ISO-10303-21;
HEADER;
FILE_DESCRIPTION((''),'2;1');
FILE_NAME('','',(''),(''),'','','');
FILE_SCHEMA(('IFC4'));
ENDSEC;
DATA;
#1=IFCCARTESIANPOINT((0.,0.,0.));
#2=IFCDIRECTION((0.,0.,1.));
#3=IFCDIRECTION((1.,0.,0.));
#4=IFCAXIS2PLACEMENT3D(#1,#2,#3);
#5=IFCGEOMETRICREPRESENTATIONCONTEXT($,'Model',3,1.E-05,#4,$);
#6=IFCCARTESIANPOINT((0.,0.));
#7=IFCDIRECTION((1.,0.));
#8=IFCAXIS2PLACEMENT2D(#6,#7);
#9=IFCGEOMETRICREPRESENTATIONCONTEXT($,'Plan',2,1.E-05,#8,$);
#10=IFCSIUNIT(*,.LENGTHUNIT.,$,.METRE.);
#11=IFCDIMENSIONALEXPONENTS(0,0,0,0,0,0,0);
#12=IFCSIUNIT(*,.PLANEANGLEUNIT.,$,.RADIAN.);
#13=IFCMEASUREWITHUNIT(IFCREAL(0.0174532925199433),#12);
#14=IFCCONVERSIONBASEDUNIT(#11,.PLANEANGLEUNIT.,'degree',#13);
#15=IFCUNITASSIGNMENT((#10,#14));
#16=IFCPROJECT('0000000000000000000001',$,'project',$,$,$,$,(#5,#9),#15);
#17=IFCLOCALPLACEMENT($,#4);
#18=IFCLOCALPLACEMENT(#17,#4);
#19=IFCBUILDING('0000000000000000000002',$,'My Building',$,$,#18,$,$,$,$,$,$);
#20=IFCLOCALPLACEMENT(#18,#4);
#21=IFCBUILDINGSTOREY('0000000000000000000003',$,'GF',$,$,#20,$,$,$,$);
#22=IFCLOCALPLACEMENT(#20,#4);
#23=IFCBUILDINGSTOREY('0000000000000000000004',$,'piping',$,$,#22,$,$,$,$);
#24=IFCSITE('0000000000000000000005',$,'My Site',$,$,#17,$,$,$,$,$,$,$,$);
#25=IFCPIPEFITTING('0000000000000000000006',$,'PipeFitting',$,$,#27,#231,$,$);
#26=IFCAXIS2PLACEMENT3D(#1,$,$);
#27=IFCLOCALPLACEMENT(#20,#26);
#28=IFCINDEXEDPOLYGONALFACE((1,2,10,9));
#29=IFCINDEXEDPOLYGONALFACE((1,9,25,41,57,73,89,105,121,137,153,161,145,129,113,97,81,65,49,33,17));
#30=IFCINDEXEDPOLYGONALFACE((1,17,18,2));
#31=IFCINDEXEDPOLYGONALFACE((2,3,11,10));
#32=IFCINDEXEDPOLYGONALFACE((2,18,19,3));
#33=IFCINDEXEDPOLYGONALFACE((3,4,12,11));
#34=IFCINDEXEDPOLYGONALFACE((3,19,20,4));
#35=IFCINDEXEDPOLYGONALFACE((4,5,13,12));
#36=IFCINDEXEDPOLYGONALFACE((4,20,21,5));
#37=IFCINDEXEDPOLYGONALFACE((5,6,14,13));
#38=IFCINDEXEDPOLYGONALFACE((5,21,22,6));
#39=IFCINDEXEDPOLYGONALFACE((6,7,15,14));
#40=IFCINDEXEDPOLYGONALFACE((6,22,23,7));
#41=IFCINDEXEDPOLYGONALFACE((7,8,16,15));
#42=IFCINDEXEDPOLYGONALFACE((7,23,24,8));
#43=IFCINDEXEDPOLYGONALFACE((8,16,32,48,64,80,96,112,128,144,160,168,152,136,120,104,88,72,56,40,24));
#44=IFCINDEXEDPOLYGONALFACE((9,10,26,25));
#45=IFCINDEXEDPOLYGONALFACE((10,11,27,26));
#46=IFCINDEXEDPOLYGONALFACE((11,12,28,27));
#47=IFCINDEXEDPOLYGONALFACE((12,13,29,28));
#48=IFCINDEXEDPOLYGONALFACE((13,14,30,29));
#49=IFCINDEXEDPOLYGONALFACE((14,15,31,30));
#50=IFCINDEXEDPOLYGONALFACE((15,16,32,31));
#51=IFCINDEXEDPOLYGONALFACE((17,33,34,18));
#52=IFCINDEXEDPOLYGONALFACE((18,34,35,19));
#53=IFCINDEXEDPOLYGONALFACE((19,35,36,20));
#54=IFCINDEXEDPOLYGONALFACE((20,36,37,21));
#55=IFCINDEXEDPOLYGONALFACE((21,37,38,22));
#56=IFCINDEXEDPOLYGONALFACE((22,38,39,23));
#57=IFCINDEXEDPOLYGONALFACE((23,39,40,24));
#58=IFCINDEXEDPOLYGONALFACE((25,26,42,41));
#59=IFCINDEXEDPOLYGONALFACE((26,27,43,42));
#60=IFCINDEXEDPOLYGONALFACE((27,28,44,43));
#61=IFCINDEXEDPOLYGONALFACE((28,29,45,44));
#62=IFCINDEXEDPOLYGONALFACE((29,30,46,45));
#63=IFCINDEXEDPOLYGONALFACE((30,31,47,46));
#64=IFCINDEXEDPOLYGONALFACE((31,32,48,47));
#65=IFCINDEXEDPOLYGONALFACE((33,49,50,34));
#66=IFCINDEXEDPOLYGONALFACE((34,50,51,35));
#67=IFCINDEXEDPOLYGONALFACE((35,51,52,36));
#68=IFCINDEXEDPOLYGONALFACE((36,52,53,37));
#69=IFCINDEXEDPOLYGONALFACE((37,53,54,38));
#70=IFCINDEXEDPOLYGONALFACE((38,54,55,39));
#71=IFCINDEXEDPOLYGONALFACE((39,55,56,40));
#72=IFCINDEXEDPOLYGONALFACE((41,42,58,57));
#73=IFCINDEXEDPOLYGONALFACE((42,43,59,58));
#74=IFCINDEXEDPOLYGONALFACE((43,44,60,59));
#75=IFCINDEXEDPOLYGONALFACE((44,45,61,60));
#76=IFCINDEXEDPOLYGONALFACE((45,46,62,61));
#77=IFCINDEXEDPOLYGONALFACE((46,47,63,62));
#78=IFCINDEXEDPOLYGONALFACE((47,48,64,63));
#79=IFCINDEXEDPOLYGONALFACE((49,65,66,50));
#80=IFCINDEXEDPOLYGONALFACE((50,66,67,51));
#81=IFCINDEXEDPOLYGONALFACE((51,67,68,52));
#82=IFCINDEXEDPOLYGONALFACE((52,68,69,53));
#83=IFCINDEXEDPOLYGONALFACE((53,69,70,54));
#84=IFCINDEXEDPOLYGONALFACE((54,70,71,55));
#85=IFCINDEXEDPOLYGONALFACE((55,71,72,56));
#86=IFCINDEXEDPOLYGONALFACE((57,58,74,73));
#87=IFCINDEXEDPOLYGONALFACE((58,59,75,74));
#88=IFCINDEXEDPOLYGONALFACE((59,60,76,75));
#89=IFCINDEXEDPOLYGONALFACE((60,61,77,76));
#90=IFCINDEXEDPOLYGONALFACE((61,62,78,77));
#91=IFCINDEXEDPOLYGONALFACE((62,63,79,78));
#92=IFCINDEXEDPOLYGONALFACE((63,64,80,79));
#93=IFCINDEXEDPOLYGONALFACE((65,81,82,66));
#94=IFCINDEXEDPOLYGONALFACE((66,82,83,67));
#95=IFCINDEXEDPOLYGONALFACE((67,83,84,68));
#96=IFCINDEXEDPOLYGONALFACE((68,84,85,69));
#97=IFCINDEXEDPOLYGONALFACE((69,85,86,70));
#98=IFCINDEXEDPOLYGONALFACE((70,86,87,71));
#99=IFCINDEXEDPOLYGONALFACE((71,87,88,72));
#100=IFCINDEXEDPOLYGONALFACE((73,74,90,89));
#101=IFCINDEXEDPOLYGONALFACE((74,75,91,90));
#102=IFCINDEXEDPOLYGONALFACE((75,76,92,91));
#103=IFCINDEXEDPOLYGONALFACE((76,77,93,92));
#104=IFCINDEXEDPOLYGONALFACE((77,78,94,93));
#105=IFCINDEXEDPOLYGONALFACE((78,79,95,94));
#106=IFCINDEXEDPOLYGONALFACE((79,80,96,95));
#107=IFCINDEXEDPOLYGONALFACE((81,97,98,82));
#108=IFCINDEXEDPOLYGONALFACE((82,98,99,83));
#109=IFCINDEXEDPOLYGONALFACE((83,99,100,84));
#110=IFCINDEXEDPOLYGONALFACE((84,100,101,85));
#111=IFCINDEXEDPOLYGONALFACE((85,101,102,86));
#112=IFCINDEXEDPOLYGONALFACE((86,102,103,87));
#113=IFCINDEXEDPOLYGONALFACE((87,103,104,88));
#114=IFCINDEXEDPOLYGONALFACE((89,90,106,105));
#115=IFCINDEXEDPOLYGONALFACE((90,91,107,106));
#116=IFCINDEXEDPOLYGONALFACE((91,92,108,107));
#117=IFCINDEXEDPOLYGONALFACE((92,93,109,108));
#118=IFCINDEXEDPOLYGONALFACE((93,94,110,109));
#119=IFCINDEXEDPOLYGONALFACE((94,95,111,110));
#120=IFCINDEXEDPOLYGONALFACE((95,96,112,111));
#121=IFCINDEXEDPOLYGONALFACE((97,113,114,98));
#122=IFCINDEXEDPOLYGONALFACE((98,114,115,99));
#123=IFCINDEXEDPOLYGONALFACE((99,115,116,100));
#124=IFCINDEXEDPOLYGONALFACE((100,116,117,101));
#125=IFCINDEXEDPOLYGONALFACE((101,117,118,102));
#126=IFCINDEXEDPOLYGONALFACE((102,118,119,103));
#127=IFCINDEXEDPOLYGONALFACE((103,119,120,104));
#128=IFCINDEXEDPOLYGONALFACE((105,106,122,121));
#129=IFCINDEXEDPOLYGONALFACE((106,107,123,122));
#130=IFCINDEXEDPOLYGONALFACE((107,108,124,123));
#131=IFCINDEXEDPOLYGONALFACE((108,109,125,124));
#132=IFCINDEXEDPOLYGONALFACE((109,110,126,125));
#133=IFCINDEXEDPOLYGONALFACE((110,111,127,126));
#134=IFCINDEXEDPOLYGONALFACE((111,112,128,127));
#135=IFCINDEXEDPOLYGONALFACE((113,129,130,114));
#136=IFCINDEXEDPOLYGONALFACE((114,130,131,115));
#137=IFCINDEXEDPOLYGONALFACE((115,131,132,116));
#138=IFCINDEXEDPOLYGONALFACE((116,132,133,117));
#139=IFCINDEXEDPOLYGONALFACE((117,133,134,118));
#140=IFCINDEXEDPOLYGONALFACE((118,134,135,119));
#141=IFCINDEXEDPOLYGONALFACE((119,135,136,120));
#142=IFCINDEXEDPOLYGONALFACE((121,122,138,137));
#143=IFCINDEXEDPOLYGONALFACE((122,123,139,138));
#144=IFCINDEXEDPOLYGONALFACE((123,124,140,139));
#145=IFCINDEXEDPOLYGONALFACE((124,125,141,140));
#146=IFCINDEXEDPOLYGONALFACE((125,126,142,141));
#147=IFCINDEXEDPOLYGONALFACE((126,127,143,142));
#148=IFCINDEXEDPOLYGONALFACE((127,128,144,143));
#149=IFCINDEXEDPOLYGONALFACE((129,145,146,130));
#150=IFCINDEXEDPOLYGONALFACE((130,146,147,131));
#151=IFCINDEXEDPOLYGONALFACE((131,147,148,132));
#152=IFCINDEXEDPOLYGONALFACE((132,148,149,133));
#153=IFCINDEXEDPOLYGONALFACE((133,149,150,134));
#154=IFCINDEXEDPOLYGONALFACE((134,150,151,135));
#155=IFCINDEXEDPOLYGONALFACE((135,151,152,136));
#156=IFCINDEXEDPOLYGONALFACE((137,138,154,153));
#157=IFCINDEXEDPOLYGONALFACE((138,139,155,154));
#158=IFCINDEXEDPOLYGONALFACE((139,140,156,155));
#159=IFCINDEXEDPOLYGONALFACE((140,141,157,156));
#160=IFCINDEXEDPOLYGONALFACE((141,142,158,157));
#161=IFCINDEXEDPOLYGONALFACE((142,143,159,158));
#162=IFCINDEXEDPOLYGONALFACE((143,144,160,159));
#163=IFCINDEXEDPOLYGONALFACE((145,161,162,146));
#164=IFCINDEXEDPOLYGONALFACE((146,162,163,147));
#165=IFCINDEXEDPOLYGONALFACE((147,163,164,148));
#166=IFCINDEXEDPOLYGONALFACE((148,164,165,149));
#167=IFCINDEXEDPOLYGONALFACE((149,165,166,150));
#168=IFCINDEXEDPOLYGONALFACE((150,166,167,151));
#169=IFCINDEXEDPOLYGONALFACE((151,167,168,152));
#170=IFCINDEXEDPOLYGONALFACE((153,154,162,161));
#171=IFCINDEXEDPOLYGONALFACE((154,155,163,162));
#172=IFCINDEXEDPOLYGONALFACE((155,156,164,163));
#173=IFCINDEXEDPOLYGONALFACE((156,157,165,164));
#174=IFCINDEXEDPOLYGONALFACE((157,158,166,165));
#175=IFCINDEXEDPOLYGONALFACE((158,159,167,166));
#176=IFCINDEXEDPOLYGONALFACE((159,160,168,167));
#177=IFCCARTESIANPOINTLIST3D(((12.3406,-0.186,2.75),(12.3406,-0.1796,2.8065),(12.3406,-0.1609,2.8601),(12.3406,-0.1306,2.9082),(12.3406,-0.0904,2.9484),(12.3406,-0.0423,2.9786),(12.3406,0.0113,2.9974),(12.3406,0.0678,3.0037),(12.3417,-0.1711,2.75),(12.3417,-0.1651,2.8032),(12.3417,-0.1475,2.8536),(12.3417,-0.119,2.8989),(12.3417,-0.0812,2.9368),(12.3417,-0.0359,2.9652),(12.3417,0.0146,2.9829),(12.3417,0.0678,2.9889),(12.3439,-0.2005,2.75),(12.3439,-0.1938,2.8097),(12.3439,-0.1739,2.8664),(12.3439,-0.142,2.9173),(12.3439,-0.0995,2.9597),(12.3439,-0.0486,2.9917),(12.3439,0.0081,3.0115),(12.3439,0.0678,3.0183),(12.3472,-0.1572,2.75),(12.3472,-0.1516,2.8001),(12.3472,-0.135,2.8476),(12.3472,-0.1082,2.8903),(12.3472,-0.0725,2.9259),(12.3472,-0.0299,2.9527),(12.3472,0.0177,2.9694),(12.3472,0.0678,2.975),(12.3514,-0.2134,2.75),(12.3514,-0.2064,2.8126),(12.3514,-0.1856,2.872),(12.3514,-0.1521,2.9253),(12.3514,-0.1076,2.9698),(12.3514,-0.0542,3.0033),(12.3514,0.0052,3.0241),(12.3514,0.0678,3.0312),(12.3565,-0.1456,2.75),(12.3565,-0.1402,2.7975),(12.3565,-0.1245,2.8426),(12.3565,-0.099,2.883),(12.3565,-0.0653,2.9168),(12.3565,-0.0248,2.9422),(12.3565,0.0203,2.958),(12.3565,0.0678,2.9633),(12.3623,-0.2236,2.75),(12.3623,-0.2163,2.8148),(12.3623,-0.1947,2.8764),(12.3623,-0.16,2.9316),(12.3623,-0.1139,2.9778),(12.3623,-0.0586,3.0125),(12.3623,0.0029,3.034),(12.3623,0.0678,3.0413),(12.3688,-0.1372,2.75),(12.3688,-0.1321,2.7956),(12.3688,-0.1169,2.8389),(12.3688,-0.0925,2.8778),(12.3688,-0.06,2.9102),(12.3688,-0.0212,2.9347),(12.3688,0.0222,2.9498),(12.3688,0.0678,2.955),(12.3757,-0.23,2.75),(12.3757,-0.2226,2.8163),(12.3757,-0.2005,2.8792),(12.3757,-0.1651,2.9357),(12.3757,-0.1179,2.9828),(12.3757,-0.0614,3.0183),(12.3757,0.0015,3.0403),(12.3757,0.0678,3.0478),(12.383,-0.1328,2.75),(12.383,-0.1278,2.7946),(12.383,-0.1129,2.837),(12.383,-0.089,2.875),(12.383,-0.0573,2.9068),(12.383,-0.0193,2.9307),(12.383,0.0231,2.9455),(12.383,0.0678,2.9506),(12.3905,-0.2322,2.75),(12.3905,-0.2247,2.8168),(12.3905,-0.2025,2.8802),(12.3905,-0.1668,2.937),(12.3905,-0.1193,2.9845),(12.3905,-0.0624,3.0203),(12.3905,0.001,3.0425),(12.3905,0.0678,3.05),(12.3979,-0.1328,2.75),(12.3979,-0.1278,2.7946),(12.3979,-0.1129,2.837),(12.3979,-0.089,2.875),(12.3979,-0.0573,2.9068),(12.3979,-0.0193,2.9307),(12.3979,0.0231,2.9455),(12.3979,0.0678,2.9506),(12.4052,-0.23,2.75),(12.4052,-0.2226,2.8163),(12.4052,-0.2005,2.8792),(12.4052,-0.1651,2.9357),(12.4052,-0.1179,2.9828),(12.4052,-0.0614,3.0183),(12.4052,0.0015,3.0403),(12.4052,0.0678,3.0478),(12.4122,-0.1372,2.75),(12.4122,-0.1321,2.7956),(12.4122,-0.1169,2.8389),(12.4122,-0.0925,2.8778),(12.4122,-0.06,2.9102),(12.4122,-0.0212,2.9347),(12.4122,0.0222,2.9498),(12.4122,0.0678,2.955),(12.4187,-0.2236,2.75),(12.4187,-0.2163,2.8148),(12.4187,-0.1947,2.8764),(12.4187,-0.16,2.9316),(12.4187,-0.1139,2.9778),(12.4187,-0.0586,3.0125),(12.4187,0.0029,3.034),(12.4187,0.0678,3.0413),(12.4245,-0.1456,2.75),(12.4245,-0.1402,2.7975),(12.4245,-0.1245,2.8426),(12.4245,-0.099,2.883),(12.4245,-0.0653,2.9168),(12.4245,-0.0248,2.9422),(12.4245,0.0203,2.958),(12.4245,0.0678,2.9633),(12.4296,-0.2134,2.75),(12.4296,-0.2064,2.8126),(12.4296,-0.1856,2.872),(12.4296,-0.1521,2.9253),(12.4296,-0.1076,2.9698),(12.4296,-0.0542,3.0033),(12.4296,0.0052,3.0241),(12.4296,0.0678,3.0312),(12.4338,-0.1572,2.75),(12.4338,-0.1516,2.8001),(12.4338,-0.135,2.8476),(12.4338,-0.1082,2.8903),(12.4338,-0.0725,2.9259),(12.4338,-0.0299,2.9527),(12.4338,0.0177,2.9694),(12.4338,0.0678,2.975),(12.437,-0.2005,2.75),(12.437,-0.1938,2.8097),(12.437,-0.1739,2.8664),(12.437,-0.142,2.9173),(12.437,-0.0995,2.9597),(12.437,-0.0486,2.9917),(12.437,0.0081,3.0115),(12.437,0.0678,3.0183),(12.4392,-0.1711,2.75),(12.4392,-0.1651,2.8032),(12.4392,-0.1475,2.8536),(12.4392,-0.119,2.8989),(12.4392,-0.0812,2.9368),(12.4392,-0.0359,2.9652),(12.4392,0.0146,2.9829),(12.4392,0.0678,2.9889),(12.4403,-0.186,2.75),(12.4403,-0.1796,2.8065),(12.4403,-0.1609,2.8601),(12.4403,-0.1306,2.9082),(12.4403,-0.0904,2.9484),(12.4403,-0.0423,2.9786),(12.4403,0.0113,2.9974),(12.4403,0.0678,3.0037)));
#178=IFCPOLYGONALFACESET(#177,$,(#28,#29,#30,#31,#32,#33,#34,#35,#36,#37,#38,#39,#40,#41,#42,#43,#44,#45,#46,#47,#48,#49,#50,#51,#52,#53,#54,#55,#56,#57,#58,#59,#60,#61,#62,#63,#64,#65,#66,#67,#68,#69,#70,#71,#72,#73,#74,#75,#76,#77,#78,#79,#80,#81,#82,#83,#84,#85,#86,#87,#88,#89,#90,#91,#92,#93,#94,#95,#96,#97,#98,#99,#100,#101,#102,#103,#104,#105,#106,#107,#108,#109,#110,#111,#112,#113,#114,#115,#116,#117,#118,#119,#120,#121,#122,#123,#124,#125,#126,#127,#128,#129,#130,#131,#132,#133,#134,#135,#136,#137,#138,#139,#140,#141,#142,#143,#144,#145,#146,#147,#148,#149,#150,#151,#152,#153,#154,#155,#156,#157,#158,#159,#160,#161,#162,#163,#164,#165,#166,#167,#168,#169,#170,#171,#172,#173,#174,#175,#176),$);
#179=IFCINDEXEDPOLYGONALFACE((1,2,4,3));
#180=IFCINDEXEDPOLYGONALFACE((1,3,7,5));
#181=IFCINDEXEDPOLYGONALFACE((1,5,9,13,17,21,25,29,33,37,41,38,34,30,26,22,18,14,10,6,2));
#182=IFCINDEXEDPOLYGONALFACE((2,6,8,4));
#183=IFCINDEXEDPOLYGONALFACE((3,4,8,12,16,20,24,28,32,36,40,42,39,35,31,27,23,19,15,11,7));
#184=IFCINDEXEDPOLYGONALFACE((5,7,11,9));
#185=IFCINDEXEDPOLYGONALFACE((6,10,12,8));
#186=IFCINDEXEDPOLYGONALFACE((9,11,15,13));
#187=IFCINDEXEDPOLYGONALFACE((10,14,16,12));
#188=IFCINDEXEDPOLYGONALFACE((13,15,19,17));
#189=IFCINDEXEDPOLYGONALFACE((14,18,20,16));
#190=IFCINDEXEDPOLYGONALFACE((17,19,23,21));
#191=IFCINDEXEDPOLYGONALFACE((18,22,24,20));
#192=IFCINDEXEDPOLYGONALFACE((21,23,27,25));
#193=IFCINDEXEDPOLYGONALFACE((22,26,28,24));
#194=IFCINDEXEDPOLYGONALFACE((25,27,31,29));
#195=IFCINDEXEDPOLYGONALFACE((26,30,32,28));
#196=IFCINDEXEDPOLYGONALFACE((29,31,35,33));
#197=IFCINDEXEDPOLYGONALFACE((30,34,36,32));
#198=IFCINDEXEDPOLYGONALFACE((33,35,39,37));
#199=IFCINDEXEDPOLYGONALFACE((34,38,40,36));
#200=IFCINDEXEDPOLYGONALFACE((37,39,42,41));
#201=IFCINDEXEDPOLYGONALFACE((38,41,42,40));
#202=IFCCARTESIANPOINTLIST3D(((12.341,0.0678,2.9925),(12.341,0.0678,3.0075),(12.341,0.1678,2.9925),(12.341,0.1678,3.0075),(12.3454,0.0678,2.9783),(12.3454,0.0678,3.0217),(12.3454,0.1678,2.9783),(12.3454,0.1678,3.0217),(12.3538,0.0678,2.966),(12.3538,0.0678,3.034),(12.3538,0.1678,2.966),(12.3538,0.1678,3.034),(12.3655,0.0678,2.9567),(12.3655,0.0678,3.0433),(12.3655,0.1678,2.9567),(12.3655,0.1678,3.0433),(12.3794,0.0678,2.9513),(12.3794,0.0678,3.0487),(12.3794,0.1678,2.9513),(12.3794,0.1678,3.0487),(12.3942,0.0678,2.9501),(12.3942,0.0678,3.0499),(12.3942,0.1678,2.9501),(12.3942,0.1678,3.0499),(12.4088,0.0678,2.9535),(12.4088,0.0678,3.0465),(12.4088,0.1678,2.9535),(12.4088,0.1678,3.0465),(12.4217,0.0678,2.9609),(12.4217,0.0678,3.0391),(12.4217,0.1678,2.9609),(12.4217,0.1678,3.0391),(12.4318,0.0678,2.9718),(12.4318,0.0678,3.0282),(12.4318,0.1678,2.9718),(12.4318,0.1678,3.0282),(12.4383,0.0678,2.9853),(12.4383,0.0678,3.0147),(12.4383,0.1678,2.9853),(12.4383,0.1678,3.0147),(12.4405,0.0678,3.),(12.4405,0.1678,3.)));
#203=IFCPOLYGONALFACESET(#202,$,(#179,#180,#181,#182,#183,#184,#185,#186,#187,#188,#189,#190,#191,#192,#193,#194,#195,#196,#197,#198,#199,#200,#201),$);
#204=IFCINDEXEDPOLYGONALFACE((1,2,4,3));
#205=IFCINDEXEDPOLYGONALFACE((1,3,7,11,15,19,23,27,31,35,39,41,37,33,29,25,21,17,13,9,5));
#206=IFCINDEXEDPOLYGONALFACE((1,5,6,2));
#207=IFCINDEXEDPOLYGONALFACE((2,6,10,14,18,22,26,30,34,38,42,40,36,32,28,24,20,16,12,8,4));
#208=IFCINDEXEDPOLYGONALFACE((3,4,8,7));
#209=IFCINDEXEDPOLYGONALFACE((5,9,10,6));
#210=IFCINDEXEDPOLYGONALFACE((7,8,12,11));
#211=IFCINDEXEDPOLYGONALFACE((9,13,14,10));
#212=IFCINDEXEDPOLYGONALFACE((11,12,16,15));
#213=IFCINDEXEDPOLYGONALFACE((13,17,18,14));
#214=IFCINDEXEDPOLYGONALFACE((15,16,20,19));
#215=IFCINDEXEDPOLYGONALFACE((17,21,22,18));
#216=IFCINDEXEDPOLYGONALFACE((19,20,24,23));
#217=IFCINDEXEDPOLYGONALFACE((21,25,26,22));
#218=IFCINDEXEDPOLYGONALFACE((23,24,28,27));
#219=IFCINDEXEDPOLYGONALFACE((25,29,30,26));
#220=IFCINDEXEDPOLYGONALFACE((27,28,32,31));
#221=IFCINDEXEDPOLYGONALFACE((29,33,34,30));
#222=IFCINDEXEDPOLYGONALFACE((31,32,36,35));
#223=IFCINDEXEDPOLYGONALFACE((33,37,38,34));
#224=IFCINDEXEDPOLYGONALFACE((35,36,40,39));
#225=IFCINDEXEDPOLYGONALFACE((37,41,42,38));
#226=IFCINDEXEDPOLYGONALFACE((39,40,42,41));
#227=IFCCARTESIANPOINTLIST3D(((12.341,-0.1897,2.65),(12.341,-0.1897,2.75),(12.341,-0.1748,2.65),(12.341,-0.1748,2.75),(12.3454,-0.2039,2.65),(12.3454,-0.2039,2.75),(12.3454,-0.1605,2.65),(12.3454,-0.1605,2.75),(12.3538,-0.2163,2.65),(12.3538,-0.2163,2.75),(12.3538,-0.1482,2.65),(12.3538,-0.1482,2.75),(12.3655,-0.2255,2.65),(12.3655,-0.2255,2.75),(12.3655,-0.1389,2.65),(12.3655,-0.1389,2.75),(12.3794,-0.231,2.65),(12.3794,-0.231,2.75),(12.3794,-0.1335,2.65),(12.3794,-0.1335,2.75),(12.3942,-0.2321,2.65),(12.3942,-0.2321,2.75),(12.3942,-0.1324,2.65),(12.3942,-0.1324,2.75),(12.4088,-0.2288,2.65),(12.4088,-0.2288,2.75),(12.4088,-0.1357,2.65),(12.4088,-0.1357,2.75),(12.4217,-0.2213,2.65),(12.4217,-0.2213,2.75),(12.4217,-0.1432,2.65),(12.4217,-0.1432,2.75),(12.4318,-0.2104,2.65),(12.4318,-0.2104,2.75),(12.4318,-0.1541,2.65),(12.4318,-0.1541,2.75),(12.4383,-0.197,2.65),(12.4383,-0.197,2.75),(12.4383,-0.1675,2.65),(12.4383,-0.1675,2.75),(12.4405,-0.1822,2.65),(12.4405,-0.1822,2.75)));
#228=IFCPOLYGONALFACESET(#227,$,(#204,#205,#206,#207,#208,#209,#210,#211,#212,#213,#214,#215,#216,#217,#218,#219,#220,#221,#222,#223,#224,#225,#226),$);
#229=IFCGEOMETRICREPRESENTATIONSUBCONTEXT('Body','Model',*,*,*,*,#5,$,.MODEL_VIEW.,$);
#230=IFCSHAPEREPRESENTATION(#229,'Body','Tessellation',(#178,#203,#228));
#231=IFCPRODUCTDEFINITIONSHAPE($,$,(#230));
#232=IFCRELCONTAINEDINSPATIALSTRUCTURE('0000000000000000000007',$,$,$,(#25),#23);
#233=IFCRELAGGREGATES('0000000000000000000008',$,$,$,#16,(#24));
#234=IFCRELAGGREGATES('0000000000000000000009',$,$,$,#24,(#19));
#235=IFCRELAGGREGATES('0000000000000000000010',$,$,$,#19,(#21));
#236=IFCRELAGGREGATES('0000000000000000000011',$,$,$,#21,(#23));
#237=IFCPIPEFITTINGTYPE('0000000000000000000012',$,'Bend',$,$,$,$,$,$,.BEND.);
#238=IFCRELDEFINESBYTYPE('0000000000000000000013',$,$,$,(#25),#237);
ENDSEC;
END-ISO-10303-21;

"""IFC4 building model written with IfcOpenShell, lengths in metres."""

from ifc_helpers import new_model, entity, si_unit, converted_unit, frame, origin_with_axes, origin_2d_with_axis, place, context, subcontext, project, spatial, circle, extrude, source, transform, mapped, type_object, type_shapes, element, save


model = new_model("IFC4")

# Units and contexts
model_context = context("Model", 3, precision=1e-05, world=origin_with_axes())
plan_context = context("Plan", 2, precision=1e-05, world=origin_2d_with_axis())
body_context = subcontext(model_context, "Body", "Model", "MODEL_VIEW")
ifc_project = project(units=[si_unit("LENGTHUNIT", "METRE"), converted_unit("PLANEANGLEUNIT", "degree", entity("IfcReal", 0.0174532925199433), si_unit("PLANEANGLEUNIT", "RADIAN"), dimensions=[0, 0, 0, 0, 0, 0, 0])], contexts=[model_context, plan_context])

# Site, building, storeys
site_placement = place(None, origin_with_axes())
site = spatial("IfcSite", under=ifc_project, at=site_placement, Name="My Site")
building_placement = place(site_placement, origin_with_axes())
building = spatial("IfcBuilding", under=site, at=building_placement, Name="My Building")
storey_1_placement = place(building_placement, origin_with_axes())
storey_1 = spatial("IfcBuildingStorey", under=building, at=storey_1_placement, Name="GF")
storey_2_placement = place(storey_1_placement, origin_with_axes())
storey_2 = spatial("IfcBuildingStorey", under=storey_1, at=storey_2_placement, Name="piping")

# Pipe fitting
pipe_fitting_type = type_object("IfcPipeFittingType", Name="Bend", PredefinedType="BEND")
shared_shape = source(origin_with_axes(), body_context, "Body", "SolidModel", [
    entity("IfcSweptDiskSolid", entity("IfcIndexedPolyCurve", entity("IfcCartesianPointList3D", [[0.0, 0.0, 0.1], [0.0, -0.0732, 0.2768], [0.0, -0.25, 0.35]]), [entity("IfcArcIndex", [1, 2, 3])]), 0.05),
    extrude(circle(Radius=0.05), origin_with_axes(), (0.0, 0.0, 1.0), 0.1),
    extrude(circle(Radius=0.05), frame((0.0, -0.25, 0.35), z_axis=(0.0, -1.0, 0.0), x_axis=(1.0, 0.0, 0.0)), (0.0, 0.0, 1.0), 0.1),
])
type_shapes(pipe_fitting_type, [shared_shape])
for number, where, z_axis, x_axis, name in (
    (1, (12.3905, 0.1678, 3.0), (0.0, -1.0, 0.0), (1.0, 0.0, 0.0), "PipeFitting"),
):
    element("IfcPipeFitting", number, at=place(storey_2_placement, frame(where, z_axis=z_axis, x_axis=x_axis)), inside=storey_2, type_object=pipe_fitting_type, Name=name, context=body_context, shape_type="MappedRepresentation", body=[
        mapped(shared_shape, transform((0.0, 0.0, 0.0), x_axis=(1.0, 0.0, 0.0), y_axis=(0.0, 1.0, 0.0), z_axis=(0.0, 0.0, 1.0), scale=1.0)),
    ])

save(model, "model.ifc")
